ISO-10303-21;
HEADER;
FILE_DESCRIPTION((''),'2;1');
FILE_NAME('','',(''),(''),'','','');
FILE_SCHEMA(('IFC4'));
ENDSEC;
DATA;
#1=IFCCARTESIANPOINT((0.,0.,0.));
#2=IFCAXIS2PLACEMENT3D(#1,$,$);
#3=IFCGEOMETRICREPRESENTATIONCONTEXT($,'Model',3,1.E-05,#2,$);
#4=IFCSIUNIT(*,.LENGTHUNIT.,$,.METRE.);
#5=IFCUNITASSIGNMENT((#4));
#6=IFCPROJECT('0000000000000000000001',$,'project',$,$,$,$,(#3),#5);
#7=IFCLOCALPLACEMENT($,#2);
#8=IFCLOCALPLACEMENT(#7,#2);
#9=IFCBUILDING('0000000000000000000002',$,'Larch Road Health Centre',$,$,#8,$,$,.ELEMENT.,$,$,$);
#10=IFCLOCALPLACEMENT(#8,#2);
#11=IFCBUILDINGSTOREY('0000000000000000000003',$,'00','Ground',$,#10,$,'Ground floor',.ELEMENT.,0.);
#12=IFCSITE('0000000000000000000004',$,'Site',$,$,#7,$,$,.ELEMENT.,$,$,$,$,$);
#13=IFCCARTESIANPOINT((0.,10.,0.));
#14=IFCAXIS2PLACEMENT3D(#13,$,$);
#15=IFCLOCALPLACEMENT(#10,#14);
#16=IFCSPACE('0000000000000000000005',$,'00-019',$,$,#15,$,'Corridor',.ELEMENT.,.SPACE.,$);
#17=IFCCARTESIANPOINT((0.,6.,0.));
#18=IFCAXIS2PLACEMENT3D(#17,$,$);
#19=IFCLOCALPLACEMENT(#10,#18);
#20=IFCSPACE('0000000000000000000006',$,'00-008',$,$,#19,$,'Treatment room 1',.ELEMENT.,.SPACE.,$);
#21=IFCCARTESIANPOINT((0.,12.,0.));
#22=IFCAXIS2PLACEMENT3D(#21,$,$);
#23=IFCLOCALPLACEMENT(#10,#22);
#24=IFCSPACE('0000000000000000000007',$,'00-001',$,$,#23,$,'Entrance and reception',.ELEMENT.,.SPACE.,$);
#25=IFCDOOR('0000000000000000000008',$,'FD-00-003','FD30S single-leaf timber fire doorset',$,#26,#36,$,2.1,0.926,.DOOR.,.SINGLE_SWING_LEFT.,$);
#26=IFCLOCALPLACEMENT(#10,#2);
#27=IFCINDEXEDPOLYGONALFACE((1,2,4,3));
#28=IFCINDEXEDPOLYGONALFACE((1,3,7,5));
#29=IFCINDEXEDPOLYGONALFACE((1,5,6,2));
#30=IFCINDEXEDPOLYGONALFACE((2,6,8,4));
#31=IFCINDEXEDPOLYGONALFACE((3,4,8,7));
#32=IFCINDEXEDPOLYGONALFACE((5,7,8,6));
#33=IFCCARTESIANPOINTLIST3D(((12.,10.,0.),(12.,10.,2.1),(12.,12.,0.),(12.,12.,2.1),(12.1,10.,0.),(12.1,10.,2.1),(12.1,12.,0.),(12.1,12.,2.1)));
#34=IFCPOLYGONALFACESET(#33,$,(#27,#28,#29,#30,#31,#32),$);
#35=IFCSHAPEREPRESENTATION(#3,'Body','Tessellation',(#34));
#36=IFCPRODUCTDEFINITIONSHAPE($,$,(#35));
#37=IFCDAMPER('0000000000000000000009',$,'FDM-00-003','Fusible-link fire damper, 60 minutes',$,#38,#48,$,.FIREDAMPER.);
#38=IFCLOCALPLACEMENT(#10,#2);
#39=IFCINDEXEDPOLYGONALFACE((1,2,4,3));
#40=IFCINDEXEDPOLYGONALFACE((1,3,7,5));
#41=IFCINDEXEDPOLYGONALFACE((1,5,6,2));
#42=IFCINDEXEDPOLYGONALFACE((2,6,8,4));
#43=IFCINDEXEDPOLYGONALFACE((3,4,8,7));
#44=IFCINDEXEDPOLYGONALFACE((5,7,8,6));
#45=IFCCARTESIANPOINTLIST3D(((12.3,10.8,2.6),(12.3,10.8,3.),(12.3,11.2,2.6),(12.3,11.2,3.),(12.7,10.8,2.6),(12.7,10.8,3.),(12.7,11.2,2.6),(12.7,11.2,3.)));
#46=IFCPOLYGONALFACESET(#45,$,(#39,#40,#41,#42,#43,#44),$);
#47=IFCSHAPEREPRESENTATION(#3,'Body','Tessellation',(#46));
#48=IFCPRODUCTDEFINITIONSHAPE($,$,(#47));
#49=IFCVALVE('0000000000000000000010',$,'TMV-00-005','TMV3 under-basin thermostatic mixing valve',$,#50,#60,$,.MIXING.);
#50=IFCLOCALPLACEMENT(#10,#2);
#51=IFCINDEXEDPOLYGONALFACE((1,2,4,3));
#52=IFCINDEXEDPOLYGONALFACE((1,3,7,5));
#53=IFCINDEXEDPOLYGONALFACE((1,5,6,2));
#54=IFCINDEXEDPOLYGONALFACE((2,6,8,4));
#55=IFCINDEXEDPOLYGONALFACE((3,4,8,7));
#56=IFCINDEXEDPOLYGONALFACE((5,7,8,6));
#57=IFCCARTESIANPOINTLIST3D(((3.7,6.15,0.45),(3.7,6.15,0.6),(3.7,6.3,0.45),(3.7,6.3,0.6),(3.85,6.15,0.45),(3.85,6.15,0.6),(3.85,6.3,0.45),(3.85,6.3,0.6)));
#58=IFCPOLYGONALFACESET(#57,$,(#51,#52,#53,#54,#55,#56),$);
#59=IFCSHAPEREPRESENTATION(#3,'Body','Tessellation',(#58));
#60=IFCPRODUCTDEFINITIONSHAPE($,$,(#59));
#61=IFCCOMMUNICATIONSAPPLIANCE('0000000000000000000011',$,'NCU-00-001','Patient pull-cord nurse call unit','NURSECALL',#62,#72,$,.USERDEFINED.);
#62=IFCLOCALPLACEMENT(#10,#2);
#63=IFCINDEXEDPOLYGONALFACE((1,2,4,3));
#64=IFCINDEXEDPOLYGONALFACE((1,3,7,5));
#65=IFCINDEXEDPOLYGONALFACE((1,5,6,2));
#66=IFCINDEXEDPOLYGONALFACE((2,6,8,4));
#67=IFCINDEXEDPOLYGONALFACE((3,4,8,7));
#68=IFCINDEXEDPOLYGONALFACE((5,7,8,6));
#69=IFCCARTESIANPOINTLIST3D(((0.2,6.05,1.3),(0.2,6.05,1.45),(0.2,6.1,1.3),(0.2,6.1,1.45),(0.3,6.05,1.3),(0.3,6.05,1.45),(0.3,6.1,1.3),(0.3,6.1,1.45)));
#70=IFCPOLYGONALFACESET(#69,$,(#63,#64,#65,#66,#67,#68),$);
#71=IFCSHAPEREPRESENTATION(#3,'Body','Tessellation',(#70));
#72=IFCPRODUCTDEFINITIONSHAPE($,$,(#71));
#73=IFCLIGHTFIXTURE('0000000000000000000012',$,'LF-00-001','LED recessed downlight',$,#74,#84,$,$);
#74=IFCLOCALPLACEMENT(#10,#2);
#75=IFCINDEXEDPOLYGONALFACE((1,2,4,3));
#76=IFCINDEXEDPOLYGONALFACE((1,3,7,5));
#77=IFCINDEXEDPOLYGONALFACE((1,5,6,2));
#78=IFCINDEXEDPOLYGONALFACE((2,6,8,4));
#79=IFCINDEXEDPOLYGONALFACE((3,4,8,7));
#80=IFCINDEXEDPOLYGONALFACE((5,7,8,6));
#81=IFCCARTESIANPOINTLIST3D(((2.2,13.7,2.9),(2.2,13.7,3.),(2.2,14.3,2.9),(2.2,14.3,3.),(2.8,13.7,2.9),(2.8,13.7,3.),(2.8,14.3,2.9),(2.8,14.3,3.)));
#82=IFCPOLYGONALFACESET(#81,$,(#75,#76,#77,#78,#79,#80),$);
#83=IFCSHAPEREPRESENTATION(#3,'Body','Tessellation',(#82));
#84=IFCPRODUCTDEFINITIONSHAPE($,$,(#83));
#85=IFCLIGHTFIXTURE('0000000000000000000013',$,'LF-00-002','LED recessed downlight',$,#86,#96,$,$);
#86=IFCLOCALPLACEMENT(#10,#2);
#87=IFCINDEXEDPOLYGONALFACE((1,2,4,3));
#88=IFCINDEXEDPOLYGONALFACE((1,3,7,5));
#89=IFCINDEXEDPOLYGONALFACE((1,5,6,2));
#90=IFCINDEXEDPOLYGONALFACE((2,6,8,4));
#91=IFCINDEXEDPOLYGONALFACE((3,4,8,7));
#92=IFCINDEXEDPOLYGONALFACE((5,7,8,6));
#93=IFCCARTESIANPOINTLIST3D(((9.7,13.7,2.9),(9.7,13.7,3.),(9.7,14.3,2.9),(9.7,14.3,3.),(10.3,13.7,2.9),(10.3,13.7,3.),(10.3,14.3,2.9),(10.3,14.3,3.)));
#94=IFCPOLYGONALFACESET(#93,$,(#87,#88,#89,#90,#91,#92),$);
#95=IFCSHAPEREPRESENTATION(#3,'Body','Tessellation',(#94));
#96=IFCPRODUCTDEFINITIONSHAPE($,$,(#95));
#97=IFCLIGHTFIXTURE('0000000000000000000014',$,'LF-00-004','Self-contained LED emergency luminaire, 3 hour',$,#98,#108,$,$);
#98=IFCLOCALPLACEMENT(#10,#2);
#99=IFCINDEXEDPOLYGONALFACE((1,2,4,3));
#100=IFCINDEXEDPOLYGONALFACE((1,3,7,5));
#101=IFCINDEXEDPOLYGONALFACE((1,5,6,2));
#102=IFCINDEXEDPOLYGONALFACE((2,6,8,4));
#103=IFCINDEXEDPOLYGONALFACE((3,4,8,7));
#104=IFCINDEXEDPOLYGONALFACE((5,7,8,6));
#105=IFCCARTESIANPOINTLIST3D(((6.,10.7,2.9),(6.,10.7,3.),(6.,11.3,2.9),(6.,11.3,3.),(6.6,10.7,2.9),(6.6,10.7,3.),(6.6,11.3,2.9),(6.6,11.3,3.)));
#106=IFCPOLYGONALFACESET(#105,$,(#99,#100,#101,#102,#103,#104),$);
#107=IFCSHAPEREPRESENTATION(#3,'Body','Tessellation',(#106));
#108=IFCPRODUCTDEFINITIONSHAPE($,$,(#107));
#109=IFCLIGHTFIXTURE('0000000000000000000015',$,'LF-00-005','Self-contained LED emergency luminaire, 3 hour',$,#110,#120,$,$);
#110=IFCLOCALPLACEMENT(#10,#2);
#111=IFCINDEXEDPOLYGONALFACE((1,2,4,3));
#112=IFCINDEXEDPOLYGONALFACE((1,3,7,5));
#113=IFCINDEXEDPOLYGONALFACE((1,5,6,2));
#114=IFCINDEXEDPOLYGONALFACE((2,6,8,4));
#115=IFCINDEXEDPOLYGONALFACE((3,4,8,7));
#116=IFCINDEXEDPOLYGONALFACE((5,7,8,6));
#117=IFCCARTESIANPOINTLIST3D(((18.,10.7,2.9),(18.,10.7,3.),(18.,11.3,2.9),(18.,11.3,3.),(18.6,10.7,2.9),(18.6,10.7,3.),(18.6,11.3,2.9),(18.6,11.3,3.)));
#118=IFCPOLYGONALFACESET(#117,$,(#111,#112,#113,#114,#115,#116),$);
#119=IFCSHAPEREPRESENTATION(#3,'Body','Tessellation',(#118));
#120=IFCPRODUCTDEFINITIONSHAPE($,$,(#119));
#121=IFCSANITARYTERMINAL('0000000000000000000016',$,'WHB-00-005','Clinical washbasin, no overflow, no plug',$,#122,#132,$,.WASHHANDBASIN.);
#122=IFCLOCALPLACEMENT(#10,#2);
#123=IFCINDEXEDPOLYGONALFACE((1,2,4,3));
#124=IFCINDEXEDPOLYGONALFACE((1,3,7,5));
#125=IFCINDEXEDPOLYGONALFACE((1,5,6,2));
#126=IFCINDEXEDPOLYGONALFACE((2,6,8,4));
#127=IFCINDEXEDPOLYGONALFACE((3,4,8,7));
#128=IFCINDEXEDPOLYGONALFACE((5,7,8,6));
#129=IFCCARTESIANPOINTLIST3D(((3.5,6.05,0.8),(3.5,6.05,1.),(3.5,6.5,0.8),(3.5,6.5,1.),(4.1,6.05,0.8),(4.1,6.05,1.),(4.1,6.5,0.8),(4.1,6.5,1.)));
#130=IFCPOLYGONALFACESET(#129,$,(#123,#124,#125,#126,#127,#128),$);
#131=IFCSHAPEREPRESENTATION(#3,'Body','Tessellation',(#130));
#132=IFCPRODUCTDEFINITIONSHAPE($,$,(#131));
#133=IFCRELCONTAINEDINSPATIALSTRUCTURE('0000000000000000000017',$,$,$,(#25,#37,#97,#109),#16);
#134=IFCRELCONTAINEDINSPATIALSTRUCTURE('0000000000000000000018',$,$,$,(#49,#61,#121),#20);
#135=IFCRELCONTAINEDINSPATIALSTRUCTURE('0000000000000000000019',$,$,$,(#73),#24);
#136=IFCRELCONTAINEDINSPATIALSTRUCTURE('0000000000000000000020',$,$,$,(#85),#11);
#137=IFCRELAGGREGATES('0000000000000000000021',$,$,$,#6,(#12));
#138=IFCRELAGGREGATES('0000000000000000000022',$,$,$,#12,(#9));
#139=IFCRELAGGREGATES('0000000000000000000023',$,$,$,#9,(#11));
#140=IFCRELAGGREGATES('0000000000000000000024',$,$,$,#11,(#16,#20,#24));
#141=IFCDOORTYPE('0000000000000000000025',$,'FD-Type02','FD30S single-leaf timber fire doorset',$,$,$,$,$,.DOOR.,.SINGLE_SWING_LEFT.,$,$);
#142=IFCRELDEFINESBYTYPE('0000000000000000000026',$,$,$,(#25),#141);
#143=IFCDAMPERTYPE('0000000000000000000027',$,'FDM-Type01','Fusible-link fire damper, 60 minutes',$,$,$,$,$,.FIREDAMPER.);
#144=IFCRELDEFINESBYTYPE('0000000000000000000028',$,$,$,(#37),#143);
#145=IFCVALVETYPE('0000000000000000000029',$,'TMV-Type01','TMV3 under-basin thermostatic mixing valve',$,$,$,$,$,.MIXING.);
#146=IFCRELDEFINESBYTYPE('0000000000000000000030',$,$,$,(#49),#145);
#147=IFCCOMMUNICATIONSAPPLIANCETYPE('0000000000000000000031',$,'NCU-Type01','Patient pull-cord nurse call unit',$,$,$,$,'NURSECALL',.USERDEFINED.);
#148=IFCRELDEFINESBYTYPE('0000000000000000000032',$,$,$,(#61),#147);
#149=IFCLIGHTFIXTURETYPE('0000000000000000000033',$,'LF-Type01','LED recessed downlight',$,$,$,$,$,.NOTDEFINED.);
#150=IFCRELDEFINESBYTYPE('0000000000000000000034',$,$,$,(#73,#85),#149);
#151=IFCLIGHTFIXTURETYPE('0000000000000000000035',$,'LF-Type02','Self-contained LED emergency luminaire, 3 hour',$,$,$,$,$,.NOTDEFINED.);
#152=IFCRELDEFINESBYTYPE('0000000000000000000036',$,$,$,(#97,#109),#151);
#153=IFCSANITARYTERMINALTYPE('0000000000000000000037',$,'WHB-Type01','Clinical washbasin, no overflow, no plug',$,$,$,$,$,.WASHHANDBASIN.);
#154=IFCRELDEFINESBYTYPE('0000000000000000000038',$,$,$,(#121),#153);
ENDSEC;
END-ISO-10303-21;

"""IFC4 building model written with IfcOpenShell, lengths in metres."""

from ifc_helpers import new_model, si_unit, frame, frame_2d, origin, place, context, project, spatial, rectangle, extrude, type_object, element, save


model = new_model("IFC4")

# Units and contexts
model_context = context("Model", 3, precision=1e-05, world=origin())
ifc_project = project(units=[si_unit("LENGTHUNIT", "METRE")], contexts=[model_context])

# Site, building, storey, space
site_placement = place(None, origin())
site = spatial("IfcSite", under=ifc_project, at=site_placement, Name="Site", CompositionType="ELEMENT")
building_placement = place(site_placement, origin())
building = spatial("IfcBuilding", under=site, at=building_placement, Name="Larch Road Health Centre", CompositionType="ELEMENT")
storey_placement = place(building_placement, origin())
storey = spatial("IfcBuildingStorey", under=building, at=storey_placement, Name="00", Description="Ground", LongName="Ground floor", CompositionType="ELEMENT", Elevation=0.0)
space_1_placement = place(storey_placement, frame((0.0, 10.0, 0.0)))
space_1 = spatial("IfcSpace", under=storey, at=space_1_placement, Name="00-019", LongName="Corridor", CompositionType="ELEMENT", PredefinedType="SPACE")

# Door
door_type = type_object("IfcDoorType", Name="FD-Type02", Description="FD30S single-leaf timber fire doorset", OperationType="SINGLE_SWING_LEFT", PredefinedType="DOOR")
door_placement = place(space_1_placement, frame((12.0, 0.0, 0.0)))
element("IfcDoor", 1, at=door_placement, inside=space_1, type_object=door_type, Name="FD-00-003", Description="FD30S single-leaf timber fire doorset", OperationType="SINGLE_SWING_LEFT", OverallHeight=2.1, OverallWidth=0.926, PredefinedType="DOOR", context=model_context, shape_type="SweptSolid", body=[
    extrude(rectangle(XDim=0.1, YDim=2.0, at=frame_2d((0.05, 1.0))), origin(), (0.0, 0.0, 1.0), 2.1),
])

# Damper
damper_type = type_object("IfcDamperType", Name="FDM-Type01", Description="Fusible-link fire damper, 60 minutes", PredefinedType="FIREDAMPER")
damper_placement = place(space_1_placement, frame((12.3, 0.8, 2.6)))
element("IfcDamper", 2, at=damper_placement, inside=space_1, type_object=damper_type, Name="FDM-00-003", Description="Fusible-link fire damper, 60 minutes", PredefinedType="FIREDAMPER", context=model_context, shape_type="SweptSolid", body=[
    extrude(rectangle(XDim=0.4, YDim=0.4, at=frame_2d((0.2, 0.2))), origin(), (0.0, 0.0, 1.0), 0.4),
])

# Shared definitions
space_2_placement = place(storey_placement, frame((0.0, 6.0, 0.0)))
space_2 = spatial("IfcSpace", under=storey, at=space_2_placement, Name="00-008", LongName="Treatment room 1", CompositionType="ELEMENT", PredefinedType="SPACE")

# Valve
valve_type = type_object("IfcValveType", Name="TMV-Type01", Description="TMV3 under-basin thermostatic mixing valve", PredefinedType="MIXING")
valve_1_placement = place(space_2_placement, frame((3.7, 0.15, 0.45)))
element("IfcValve", 3, at=valve_1_placement, inside=space_2, type_object=valve_type, Name="TMV-00-005", Description="TMV3 under-basin thermostatic mixing valve", PredefinedType="MIXING", context=model_context, shape_type="SweptSolid", body=[
    extrude(rectangle(XDim=0.15, YDim=0.15, at=frame_2d((0.075, 0.075))), origin(), (0.0, 0.0, 1.0), 0.15),
])

# Communications appliance
communications_appliance_type_1 = type_object("IfcCommunicationsApplianceType", Name="NCU-Type01", Description="Patient pull-cord nurse call unit", ElementType="NURSECALL", PredefinedType="USERDEFINED")
communications_appliance_1_placement = place(space_2_placement, frame((0.2, 0.05, 1.3)))
element("IfcCommunicationsAppliance", 4, at=communications_appliance_1_placement, inside=space_2, type_object=communications_appliance_type_1, Name="NCU-00-001", Description="Patient pull-cord nurse call unit", ObjectType="NURSECALL", PredefinedType="USERDEFINED", context=model_context, shape_type="SweptSolid", body=[
    extrude(rectangle(XDim=0.1, YDim=0.05, at=frame_2d((0.05, 0.025))), origin(), (0.0, 0.0, 1.0), 0.15),
])

# Shared definitions
space_3_placement = place(storey_placement, frame((0.0, 12.0, 0.0)))
space_3 = spatial("IfcSpace", under=storey, at=space_3_placement, Name="00-001", LongName="Entrance and reception", CompositionType="ELEMENT", PredefinedType="SPACE")

# Light fixtures
light_fixture_type_1 = type_object("IfcLightFixtureType", Name="LF-Type01", Description="LED recessed downlight", PredefinedType="NOTDEFINED")
light_fixture_1_placement = place(space_3_placement, frame((2.2, 1.7, 2.9)))
element("IfcLightFixture", 5, at=light_fixture_1_placement, inside=space_3, type_object=light_fixture_type_1, Name="LF-00-001", Description="LED recessed downlight", context=model_context, shape_type="SweptSolid", body=[
    extrude(rectangle(XDim=0.6, YDim=0.6, at=frame_2d((0.3, 0.3))), origin(), (0.0, 0.0, 1.0), 0.1),
])
light_fixture_2_placement = place(storey_placement, frame((9.7, 13.7, 2.9)))
element("IfcLightFixture", 6, at=light_fixture_2_placement, inside=storey, type_object=light_fixture_type_1, Name="LF-00-002", Description="LED recessed downlight", context=model_context, shape_type="SweptSolid", body=[
    extrude(rectangle(XDim=0.6, YDim=0.6, at=frame_2d((0.3, 0.3))), origin(), (0.0, 0.0, 1.0), 0.1),
])

# Light fixtures
light_fixture_type_2 = type_object("IfcLightFixtureType", Name="LF-Type02", Description="Self-contained LED emergency luminaire, 3 hour", PredefinedType="NOTDEFINED")
for number, where, name in (
    (7, (6.0, 0.7, 2.9), "LF-00-004"),
    (8, (18.0, 0.7, 2.9), "LF-00-005"),
):
    element("IfcLightFixture", number, at=place(space_1_placement, frame(where)), inside=space_1, type_object=light_fixture_type_2, Name=name, Description="Self-contained LED emergency luminaire, 3 hour", context=model_context, shape_type="SweptSolid", body=[
        extrude(rectangle(XDim=0.6, YDim=0.6, at=frame_2d((0.3, 0.3))), origin(), (0.0, 0.0, 1.0), 0.1),
    ])

# Sanitary terminal
sanitary_terminal_type_1 = type_object("IfcSanitaryTerminalType", Name="WHB-Type01", Description="Clinical washbasin, no overflow, no plug", PredefinedType="WASHHANDBASIN")
sanitary_terminal_1_placement = place(space_2_placement, frame((3.5, 0.05, 0.8)))
element("IfcSanitaryTerminal", 9, at=sanitary_terminal_1_placement, inside=space_2, type_object=sanitary_terminal_type_1, Name="WHB-00-005", Description="Clinical washbasin, no overflow, no plug", PredefinedType="WASHHANDBASIN", context=model_context, shape_type="SweptSolid", body=[
    extrude(rectangle(XDim=0.6, YDim=0.45, at=frame_2d((0.3, 0.225))), origin(), (0.0, 0.0, 1.0), 0.2),
])

save(model, "model.ifc")
